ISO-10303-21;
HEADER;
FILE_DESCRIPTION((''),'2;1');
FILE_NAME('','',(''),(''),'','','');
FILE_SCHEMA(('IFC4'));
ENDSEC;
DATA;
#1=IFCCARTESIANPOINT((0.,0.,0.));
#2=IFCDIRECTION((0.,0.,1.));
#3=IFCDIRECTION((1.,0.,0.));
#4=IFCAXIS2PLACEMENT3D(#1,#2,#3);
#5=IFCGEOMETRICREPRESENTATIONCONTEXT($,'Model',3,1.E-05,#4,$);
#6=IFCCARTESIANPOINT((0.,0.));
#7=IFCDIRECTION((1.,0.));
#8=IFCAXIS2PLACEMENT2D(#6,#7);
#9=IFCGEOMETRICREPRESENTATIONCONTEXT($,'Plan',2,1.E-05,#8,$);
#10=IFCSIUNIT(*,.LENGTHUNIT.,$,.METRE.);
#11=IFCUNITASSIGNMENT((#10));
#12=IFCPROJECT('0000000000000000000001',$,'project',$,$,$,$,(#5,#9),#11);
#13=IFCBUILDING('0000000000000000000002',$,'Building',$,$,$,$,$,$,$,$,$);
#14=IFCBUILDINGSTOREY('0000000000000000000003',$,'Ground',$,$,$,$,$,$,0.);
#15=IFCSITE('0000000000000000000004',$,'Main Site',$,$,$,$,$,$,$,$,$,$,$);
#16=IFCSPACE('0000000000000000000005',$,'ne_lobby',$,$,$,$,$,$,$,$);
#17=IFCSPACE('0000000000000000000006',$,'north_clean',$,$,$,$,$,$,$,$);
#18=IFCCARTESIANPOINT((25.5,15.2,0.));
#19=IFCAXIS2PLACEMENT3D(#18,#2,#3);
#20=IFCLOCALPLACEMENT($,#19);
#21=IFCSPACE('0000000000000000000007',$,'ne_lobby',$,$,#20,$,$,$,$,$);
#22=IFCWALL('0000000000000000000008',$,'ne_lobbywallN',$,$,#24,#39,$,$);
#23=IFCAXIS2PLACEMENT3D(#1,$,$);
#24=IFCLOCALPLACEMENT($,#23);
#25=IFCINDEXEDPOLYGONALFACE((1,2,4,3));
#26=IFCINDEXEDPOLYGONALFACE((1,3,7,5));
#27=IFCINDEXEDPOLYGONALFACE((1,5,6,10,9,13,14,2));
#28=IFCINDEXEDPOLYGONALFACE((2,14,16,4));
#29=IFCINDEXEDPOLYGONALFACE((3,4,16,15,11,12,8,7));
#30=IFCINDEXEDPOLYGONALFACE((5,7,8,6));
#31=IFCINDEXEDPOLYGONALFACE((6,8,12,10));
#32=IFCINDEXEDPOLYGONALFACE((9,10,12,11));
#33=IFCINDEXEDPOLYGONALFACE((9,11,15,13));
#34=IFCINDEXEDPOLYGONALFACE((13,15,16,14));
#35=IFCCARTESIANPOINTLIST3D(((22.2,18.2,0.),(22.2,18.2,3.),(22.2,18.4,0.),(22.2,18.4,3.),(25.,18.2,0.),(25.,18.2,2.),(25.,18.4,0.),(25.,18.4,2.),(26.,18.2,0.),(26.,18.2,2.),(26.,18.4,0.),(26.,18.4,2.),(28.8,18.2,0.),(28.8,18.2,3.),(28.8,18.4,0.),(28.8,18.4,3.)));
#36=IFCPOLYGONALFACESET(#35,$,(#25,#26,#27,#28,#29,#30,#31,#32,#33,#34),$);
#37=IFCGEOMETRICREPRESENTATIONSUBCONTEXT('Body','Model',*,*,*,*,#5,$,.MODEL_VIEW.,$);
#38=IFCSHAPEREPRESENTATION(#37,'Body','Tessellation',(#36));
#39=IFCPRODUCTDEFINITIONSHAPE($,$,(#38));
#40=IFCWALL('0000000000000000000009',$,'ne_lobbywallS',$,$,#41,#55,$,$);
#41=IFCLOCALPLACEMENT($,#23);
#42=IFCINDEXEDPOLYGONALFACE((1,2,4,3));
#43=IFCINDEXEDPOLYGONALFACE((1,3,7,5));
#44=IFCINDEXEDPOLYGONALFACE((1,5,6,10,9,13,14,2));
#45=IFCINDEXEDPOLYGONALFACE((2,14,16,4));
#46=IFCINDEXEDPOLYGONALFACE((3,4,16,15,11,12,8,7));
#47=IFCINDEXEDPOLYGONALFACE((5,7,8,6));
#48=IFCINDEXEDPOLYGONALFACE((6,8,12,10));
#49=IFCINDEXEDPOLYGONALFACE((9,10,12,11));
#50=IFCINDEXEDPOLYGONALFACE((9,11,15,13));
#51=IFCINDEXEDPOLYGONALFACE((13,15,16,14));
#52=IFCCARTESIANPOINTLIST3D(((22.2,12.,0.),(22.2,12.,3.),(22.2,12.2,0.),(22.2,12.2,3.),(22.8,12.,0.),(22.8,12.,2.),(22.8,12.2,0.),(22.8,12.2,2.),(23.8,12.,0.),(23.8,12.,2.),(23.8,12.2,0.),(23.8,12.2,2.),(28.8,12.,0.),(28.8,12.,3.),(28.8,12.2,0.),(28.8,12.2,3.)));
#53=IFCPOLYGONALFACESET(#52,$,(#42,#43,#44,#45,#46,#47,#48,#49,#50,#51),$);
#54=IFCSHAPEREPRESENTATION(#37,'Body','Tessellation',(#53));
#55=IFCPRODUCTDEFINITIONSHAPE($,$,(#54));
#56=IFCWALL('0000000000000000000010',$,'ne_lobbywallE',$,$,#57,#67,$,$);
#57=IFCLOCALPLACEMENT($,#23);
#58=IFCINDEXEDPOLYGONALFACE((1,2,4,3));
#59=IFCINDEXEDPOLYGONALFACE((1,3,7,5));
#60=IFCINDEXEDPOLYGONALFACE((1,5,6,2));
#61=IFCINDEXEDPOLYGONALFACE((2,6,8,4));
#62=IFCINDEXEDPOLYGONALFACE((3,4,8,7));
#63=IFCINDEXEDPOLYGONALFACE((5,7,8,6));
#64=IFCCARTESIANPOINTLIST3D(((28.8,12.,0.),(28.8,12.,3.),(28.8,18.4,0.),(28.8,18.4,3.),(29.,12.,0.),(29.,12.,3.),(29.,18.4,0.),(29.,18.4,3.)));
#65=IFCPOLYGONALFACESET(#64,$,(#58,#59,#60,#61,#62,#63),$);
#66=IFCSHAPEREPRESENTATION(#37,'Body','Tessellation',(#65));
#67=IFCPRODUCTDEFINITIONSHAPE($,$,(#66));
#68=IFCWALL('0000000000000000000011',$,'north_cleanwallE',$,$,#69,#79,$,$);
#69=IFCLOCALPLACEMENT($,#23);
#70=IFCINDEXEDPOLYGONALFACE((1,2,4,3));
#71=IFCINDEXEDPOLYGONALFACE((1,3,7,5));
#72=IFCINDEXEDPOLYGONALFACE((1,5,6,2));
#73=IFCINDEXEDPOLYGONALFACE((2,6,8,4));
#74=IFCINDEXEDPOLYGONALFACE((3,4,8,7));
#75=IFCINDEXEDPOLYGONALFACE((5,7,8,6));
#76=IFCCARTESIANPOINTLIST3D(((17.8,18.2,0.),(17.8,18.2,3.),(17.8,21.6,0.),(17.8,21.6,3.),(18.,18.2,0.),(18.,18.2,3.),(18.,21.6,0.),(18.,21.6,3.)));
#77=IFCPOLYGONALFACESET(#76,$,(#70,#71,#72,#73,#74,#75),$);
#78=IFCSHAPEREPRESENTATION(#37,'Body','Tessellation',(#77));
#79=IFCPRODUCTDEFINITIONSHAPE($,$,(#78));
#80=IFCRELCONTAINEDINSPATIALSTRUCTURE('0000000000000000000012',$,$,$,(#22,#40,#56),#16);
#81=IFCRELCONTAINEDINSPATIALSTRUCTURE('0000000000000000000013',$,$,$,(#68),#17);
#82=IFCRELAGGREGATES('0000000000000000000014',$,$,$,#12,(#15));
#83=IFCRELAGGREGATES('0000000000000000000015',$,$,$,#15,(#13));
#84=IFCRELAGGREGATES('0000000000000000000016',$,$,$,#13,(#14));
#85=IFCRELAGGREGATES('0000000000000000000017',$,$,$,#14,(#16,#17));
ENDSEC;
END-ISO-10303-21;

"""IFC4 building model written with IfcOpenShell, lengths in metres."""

from ifc_helpers import new_model, si_unit, frame, origin_with_axes, origin_2d_with_axis, place, context, subcontext, project, spatial, indexed_curve, outline, extrude, element, save


model = new_model("IFC4")

# Units and contexts
model_context = context("Model", 3, precision=1e-05, world=origin_with_axes())
plan_context = context("Plan", 2, precision=1e-05, world=origin_2d_with_axis())
body_context = subcontext(model_context, "Body", "Model", "MODEL_VIEW")
ifc_project = project(units=[si_unit("LENGTHUNIT", "METRE")], contexts=[model_context, plan_context])

# Site, building, storey
site = spatial("IfcSite", under=ifc_project, Name="Main Site")
building = spatial("IfcBuilding", under=site, Name="Building")
storey = spatial("IfcBuildingStorey", under=building, Name="Ground", Elevation=0.0)

# Shared definitions
space_1 = spatial("IfcSpace", under=storey, Name="ne_lobby")

# Shared definitions
space_2 = spatial("IfcSpace", under=storey, Name="north_clean")

# Wall
wall_1_placement = place(None, frame((22.2, 18.2, 0.0), z_axis=(0.0, 0.0, 1.0), x_axis=(1.0, 0.0, 0.0)))
wall_1 = element("IfcWall", 1, at=wall_1_placement, inside=space_1, Name="ne_lobbywallN", context=body_context, shape_type="SweptSolid", body=[
    extrude(outline(indexed_curve([(0.0, 0.0), (0.0, 0.2), (6.6, 0.2), (6.6, 0.0), (0.0, 0.0)], self_intersect=False)), origin_with_axes(), (0.0, 0.0, 1.0), 3.0),
])

# Shared definitions
space_3_placement = place(None, frame((25.5, 15.2, 0.0), z_axis=(0.0, 0.0, 1.0), x_axis=(1.0, 0.0, 0.0)))
space_3 = spatial("IfcSpace", at=space_3_placement, Name="ne_lobby")

# Opening
opening_1_placement = place(wall_1_placement, frame((2.8, 0.0, 0.0), z_axis=(0.0, 0.0, 1.0), x_axis=(1.0, 0.0, 0.0)))
element("IfcOpeningElement", 2, at=opening_1_placement, inside=space_3, cuts=wall_1, context=body_context, shape_type="SweptSolid", body=[
    extrude(outline(indexed_curve([(0.0, 0.0), (0.0, 0.4), (1.0, 0.4), (1.0, 0.0), (0.0, 0.0)], self_intersect=False)), origin_with_axes(), (0.0, 0.0, 1.0), 2.0),
])

# Wall, opening
wall_2_placement = place(None, frame((22.2, 12.0, 0.0), z_axis=(0.0, 0.0, 1.0), x_axis=(1.0, 0.0, 0.0)))
wall_2 = element("IfcWall", 3, at=wall_2_placement, inside=space_1, Name="ne_lobbywallS", context=body_context, shape_type="SweptSolid", body=[
    extrude(outline(indexed_curve([(0.0, 0.0), (0.0, 0.2), (6.6, 0.2), (6.6, 0.0), (0.0, 0.0)], self_intersect=False)), origin_with_axes(), (0.0, 0.0, 1.0), 3.0),
])
opening_2_placement = place(wall_2_placement, frame((0.6, 0.0, 0.0), z_axis=(0.0, 0.0, 1.0), x_axis=(1.0, 0.0, 0.0)))
element("IfcOpeningElement", 4, at=opening_2_placement, inside=space_3, cuts=wall_2, context=body_context, shape_type="SweptSolid", body=[
    extrude(outline(indexed_curve([(0.0, 0.0), (0.0, 0.4), (1.0, 0.4), (1.0, 0.0), (0.0, 0.0)], self_intersect=False)), origin_with_axes(), (0.0, 0.0, 1.0), 2.0),
])

# Walls
for number, where, z_axis, x_axis, name in (
    (5, (29.0, 12.0, 0.0), (0.0, 0.0, 1.0), (0.0, 1.0, 0.0), "ne_lobbywallE"),
):
    element("IfcWall", number, at=place(None, frame(where, z_axis=z_axis, x_axis=x_axis)), inside=space_1, Name=name, context=body_context, shape_type="SweptSolid", body=[
        extrude(outline(indexed_curve([(0.0, 0.0), (0.0, 0.2), (6.4, 0.2), (6.4, 0.0), (0.0, 0.0)], self_intersect=False)), origin_with_axes(), (0.0, 0.0, 1.0), 3.0),
    ])
wall_3_placement = place(None, frame((18.0, 18.2, 0.0), z_axis=(0.0, 0.0, 1.0), x_axis=(0.0, 1.0, 0.0)))
element("IfcWall", 6, at=wall_3_placement, inside=space_2, Name="north_cleanwallE", context=body_context, shape_type="SweptSolid", body=[
    extrude(outline(indexed_curve([(0.0, 0.0), (0.0, 0.2), (3.4, 0.2), (3.4, 0.0), (0.0, 0.0)], self_intersect=False)), origin_with_axes(), (0.0, 0.0, 1.0), 3.0),
])

save(model, "model.ifc")
